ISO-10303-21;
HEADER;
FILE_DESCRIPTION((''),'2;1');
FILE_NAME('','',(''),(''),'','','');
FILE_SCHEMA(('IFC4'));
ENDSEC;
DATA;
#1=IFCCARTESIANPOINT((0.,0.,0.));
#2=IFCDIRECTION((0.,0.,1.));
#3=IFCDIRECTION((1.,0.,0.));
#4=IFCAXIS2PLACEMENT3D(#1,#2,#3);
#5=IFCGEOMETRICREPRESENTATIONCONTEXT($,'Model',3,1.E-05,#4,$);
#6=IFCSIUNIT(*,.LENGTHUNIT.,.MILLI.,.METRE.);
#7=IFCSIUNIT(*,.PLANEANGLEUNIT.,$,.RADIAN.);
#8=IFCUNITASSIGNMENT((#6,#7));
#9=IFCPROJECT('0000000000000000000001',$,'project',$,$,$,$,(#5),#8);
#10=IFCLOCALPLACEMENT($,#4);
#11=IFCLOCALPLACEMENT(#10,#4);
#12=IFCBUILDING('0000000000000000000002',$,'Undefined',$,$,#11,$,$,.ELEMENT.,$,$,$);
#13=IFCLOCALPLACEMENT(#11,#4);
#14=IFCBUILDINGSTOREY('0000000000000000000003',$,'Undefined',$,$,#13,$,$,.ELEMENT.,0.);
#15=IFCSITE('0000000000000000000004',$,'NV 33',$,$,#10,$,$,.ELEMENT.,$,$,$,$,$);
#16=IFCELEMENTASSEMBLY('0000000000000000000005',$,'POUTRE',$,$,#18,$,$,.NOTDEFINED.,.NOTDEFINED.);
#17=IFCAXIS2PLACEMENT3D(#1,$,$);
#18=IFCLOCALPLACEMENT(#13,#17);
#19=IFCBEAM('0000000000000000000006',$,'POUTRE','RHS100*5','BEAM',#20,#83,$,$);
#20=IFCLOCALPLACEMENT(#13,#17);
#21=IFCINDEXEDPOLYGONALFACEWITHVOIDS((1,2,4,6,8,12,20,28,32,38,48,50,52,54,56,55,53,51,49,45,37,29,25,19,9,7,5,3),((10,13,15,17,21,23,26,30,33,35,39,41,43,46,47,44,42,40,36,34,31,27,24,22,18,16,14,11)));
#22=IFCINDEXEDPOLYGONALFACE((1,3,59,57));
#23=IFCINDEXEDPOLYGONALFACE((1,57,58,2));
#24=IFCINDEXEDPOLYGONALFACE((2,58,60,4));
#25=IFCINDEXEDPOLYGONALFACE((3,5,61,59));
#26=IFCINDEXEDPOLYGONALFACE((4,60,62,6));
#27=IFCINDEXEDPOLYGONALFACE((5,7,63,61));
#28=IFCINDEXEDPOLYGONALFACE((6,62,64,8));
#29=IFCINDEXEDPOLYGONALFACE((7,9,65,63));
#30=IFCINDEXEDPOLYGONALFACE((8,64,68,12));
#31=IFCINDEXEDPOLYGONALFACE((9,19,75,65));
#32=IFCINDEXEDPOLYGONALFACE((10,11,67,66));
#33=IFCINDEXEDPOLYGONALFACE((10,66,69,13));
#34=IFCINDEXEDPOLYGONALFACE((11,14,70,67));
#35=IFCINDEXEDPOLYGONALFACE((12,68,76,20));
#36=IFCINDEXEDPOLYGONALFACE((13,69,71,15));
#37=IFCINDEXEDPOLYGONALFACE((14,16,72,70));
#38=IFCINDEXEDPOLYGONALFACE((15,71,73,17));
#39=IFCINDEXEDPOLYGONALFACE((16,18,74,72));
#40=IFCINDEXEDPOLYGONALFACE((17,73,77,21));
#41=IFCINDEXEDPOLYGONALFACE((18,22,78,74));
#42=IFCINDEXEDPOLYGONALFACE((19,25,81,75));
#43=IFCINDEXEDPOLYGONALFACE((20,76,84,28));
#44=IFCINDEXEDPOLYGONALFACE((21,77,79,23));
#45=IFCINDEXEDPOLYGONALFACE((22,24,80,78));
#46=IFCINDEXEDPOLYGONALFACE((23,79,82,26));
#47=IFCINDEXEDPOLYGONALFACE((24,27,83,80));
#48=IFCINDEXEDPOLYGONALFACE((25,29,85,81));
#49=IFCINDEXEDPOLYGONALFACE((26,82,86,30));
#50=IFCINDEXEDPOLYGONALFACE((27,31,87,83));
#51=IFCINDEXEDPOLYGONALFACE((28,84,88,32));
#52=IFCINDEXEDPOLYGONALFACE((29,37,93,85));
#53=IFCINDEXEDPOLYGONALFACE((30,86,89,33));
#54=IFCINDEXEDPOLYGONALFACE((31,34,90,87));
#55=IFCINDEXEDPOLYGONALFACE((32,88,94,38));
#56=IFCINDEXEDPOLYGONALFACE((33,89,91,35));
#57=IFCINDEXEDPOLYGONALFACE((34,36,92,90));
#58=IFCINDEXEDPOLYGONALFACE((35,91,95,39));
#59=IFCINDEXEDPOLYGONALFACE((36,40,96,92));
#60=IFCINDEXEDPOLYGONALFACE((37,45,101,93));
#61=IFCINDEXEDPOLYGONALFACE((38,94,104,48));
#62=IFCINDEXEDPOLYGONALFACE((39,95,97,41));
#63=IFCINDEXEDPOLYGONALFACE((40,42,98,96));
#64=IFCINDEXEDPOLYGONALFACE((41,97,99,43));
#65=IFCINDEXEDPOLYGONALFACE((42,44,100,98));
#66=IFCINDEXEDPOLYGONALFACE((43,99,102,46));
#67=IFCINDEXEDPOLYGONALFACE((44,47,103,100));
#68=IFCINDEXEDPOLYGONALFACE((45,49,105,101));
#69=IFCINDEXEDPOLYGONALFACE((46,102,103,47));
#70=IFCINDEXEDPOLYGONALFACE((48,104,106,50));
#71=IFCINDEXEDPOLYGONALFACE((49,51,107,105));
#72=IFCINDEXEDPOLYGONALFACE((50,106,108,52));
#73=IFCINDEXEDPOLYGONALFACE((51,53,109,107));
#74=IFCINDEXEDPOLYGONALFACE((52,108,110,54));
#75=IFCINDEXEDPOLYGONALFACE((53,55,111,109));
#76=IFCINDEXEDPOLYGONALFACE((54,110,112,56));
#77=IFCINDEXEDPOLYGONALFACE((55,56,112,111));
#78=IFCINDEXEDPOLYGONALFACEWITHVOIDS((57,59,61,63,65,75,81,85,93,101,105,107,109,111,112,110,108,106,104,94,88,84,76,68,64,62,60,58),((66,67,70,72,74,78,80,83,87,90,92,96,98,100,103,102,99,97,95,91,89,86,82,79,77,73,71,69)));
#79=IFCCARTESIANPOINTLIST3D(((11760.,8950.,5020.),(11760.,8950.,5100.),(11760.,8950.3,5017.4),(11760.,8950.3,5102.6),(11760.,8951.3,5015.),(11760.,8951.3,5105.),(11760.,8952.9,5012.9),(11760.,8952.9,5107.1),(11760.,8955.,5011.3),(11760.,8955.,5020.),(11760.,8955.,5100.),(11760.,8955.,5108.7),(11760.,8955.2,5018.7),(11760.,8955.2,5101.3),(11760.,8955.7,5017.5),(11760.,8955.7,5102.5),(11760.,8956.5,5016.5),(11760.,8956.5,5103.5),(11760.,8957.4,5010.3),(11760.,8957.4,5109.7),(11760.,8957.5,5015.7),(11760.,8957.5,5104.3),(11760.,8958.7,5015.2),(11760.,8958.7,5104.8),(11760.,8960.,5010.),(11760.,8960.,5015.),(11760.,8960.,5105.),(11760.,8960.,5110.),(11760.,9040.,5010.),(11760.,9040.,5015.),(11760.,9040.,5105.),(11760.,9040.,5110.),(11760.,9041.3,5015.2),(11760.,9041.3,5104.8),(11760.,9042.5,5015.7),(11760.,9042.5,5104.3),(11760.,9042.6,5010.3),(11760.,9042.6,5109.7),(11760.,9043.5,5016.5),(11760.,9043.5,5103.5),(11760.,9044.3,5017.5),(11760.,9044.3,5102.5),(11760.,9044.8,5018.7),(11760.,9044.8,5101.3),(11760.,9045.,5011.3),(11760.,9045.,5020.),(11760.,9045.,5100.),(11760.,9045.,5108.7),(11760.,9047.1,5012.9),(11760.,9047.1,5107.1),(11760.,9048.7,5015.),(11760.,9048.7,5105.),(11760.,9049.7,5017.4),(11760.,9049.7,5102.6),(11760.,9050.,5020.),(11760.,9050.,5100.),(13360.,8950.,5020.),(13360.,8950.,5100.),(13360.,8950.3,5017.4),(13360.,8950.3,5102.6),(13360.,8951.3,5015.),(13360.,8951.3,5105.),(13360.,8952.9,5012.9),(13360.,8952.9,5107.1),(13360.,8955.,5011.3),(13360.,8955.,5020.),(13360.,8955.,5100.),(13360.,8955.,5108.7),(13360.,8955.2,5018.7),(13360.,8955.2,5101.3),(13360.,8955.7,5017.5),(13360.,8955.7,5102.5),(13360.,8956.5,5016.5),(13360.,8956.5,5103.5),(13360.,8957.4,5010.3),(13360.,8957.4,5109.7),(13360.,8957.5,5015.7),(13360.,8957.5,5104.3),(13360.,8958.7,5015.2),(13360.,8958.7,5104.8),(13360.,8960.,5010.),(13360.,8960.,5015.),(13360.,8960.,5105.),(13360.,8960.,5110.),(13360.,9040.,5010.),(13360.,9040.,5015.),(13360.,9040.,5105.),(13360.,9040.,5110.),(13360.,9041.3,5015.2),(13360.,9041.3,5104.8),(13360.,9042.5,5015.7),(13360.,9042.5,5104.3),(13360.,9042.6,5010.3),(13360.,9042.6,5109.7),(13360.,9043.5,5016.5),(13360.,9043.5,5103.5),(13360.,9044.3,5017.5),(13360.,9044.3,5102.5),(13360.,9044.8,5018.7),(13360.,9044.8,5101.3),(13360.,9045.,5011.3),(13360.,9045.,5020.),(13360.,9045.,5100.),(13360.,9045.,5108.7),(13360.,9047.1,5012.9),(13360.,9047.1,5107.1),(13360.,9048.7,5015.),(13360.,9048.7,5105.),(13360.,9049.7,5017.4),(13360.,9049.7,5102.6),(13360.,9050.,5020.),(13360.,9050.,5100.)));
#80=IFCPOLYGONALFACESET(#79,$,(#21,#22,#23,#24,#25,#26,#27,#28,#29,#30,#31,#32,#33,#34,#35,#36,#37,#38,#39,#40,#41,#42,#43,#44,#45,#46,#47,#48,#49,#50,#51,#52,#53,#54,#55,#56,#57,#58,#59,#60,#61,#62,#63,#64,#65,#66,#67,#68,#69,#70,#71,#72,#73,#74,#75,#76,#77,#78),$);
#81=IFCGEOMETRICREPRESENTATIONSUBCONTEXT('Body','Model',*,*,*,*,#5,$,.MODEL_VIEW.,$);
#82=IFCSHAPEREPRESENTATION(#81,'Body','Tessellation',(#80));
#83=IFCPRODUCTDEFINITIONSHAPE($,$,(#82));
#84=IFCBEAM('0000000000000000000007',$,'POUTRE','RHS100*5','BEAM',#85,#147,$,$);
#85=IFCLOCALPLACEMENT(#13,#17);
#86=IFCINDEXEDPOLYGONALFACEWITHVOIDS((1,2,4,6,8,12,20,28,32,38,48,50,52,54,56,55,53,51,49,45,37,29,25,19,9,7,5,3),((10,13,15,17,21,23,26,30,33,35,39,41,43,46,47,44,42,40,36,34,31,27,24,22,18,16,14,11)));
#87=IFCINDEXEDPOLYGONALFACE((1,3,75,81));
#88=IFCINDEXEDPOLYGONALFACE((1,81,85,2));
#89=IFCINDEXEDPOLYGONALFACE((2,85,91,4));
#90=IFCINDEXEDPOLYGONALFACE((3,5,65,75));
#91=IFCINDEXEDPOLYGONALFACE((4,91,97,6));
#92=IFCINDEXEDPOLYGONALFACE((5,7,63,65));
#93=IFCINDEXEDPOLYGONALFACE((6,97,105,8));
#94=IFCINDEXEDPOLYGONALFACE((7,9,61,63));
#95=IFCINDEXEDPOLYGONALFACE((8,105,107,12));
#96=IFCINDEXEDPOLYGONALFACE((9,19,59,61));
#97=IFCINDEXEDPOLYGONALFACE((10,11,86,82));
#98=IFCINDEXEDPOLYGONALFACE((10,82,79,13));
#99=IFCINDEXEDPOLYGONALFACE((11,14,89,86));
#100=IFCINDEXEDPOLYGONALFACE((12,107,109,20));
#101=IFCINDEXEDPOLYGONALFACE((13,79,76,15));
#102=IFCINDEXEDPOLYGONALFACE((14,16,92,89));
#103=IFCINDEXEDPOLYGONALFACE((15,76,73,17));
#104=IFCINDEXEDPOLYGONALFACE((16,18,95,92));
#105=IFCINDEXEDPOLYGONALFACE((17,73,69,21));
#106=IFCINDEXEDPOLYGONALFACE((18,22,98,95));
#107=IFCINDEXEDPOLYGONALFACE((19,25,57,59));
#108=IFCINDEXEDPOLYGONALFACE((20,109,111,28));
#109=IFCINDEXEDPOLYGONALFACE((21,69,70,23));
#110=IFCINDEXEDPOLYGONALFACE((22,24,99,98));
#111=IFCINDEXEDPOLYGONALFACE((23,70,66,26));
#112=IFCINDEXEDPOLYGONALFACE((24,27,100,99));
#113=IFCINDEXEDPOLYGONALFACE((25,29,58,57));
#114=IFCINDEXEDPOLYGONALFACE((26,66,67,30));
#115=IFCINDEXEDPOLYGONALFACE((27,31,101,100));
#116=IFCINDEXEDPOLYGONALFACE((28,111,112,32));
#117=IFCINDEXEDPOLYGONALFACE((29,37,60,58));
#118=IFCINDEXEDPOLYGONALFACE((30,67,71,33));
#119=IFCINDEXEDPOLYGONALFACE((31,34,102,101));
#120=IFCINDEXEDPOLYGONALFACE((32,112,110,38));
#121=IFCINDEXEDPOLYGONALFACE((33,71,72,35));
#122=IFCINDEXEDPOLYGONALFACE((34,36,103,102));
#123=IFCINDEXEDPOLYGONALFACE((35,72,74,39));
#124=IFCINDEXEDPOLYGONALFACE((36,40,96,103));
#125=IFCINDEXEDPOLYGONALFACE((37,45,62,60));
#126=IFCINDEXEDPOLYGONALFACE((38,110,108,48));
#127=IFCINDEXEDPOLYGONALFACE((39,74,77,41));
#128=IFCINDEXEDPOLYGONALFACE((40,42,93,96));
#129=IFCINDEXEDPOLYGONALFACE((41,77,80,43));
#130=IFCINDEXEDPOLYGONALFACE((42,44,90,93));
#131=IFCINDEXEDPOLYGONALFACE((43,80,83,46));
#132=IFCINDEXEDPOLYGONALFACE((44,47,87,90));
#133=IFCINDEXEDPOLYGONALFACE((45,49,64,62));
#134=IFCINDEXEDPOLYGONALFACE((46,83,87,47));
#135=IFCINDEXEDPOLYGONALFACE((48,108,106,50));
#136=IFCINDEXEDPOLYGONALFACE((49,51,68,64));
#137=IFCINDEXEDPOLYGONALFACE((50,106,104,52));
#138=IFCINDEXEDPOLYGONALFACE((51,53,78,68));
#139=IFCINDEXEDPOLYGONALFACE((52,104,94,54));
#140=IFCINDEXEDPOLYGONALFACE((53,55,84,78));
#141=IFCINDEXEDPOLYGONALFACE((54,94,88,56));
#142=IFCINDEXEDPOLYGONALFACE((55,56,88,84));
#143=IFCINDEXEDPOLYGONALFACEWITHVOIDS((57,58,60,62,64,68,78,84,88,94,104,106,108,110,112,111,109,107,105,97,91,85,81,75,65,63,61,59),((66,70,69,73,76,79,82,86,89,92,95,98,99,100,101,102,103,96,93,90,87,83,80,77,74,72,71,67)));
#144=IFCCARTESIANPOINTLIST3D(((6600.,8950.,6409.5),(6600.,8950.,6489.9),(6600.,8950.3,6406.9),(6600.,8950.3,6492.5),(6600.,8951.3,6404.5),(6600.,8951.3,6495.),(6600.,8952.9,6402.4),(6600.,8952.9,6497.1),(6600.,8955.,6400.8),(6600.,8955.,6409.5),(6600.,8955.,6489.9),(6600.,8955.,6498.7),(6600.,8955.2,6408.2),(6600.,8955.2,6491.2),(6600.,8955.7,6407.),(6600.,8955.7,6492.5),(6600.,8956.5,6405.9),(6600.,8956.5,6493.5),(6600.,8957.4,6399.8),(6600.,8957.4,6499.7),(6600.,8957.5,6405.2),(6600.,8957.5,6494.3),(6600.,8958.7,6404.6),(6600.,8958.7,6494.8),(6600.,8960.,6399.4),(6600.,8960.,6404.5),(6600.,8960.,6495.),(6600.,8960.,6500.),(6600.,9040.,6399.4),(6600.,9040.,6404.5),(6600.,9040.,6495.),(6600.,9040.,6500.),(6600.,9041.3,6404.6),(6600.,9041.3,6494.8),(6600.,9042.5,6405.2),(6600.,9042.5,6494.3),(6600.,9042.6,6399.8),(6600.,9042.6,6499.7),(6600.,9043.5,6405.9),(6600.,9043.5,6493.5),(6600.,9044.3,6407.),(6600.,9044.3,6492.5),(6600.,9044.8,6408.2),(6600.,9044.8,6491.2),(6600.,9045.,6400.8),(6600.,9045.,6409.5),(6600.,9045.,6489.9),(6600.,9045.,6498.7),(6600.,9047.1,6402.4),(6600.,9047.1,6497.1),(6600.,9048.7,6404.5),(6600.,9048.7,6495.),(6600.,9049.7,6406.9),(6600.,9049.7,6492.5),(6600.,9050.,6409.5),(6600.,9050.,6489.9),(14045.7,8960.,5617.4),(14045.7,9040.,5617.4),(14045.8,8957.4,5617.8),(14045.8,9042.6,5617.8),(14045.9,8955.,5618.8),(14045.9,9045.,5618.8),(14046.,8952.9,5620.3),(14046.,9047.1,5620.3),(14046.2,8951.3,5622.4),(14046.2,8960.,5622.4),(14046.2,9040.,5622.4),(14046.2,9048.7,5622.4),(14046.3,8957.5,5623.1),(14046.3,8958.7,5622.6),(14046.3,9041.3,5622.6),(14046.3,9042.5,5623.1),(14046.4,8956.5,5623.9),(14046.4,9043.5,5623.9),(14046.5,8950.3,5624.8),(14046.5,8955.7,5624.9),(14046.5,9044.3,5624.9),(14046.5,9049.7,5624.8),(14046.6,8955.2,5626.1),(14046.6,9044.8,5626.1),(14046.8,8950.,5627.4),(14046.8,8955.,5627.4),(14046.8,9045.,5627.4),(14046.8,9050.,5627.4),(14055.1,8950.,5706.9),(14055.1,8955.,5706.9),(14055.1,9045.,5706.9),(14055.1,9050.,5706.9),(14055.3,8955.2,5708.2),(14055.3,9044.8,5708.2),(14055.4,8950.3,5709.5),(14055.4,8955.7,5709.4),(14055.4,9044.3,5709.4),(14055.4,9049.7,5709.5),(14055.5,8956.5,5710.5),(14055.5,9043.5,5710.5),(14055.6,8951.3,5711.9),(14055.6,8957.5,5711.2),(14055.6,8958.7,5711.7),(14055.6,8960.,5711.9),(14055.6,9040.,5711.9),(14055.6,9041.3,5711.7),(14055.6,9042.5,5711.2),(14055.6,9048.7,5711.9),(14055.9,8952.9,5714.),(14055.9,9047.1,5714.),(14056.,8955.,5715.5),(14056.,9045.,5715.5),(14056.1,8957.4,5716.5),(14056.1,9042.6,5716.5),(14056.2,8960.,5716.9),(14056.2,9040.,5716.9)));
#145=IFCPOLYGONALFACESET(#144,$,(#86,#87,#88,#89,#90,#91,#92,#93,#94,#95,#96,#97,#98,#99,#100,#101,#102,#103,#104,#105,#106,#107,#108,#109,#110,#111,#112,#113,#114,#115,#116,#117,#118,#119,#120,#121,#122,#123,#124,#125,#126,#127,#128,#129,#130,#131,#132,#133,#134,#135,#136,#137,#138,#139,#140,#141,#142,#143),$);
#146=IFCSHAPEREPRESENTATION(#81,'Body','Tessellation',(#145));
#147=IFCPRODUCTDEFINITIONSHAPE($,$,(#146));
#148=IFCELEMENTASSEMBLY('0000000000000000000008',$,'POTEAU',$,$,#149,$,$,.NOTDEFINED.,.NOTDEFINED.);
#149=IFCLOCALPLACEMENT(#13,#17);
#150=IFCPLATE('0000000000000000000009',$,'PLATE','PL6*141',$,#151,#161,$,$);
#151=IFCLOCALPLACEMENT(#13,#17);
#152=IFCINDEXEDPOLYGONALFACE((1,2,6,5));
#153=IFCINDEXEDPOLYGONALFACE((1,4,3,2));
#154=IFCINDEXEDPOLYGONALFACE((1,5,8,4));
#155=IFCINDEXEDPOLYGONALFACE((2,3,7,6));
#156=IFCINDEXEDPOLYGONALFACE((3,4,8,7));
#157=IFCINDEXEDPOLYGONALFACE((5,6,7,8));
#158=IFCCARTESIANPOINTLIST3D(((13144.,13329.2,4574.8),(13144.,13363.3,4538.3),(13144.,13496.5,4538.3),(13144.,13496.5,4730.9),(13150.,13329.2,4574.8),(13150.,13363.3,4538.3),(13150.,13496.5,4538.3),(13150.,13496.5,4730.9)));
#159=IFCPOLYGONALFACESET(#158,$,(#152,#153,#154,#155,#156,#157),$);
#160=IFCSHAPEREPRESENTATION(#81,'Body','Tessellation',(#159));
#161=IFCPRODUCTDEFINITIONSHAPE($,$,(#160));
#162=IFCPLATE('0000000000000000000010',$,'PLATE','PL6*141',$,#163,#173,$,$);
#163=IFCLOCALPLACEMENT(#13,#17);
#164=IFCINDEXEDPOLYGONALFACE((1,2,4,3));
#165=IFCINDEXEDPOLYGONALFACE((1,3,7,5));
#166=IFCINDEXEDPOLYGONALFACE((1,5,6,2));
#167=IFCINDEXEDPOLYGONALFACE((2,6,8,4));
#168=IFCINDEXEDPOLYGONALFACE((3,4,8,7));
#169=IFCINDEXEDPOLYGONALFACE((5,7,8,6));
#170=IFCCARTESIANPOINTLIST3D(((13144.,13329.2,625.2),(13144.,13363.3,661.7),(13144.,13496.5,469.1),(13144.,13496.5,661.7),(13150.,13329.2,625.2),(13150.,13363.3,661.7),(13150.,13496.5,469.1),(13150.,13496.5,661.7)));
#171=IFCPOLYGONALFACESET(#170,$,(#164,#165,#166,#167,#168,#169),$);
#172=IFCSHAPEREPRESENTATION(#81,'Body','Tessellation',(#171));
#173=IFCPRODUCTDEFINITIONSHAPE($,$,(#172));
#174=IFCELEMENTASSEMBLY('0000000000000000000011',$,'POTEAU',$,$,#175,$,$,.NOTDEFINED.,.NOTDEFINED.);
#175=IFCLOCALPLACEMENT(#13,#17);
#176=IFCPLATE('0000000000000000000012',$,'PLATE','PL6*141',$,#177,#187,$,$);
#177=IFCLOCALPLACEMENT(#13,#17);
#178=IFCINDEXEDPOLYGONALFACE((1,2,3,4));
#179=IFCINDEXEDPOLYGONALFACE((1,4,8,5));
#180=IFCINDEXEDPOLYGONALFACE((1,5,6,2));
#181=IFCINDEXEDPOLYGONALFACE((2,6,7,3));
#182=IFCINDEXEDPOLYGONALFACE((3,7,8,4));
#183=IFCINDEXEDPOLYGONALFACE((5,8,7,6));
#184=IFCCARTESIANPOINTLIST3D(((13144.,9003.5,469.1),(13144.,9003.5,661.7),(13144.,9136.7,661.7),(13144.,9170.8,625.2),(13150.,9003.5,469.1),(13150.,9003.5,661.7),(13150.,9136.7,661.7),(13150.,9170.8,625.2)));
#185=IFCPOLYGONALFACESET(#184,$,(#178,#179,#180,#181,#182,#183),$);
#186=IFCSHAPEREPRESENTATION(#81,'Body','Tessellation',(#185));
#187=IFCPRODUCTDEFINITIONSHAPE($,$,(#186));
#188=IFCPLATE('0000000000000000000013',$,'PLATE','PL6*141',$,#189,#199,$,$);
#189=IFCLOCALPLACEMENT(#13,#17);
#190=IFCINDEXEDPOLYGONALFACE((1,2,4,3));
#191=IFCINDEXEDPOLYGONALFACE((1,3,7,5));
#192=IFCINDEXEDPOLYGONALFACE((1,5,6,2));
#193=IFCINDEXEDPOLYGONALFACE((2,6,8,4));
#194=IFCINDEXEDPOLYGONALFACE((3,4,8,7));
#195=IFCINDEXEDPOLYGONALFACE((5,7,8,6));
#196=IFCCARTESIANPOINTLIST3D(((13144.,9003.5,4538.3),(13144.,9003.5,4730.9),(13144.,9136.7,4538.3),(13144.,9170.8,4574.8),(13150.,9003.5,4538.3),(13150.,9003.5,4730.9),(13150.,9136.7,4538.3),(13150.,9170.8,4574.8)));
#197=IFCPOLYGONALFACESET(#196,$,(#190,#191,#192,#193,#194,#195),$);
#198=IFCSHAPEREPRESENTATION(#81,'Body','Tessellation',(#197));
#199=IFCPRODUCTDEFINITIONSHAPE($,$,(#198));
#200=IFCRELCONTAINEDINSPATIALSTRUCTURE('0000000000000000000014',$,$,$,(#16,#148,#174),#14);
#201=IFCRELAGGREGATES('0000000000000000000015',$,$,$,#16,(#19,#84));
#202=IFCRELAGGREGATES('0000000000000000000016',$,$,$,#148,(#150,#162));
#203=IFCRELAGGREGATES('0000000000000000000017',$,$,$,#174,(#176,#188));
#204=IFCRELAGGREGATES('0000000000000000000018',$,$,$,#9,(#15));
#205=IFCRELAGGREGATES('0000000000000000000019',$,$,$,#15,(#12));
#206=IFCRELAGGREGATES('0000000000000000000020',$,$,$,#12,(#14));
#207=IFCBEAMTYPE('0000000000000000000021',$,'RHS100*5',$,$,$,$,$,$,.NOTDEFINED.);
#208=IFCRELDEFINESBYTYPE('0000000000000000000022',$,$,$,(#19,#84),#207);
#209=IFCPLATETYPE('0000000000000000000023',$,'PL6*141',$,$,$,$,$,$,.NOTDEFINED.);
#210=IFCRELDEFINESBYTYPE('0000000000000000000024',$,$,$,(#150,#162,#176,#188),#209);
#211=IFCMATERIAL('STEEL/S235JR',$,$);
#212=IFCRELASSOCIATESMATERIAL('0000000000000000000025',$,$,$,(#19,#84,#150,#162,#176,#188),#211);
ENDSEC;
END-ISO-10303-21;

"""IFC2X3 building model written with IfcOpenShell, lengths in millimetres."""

from ifc_helpers import new_model, si_unit, frame, origin_with_axes, origin_2d_with_axis, place, context, subcontext, project, spatial, polyline, hollow_rectangle, outline, extrude, clip, halfspace, material, type_object, element, aggregate, save


model = new_model("IFC2X3")

# Units and contexts
model_context = context("Model", 3, precision=1e-05, world=origin_with_axes())
body_context = subcontext(model_context, "Body", "Model", "MODEL_VIEW")
ifc_project = project(units=[si_unit("LENGTHUNIT", "METRE", prefix="MILLI"), si_unit("PLANEANGLEUNIT", "RADIAN")], contexts=[model_context])

# Site, building, storey
site_placement = place(None, origin_with_axes())
site = spatial("IfcSite", under=ifc_project, at=site_placement, Name="NV 33", CompositionType="ELEMENT")
building_placement = place(site_placement, origin_with_axes())
building = spatial("IfcBuilding", under=site, at=building_placement, Name="Undefined", CompositionType="ELEMENT")
storey_placement = place(building_placement, origin_with_axes())
storey = spatial("IfcBuildingStorey", under=building, at=storey_placement, Name="Undefined", CompositionType="ELEMENT", Elevation=0.0)

# Shared definitions
ifc_material_1 = material(Name="STEEL/S235JR")

# Element assembly, beams
beam_type_1 = type_object("IfcBeamType", Name="RHS100*5", PredefinedType="NOTDEFINED")
assembly_1_placement = place(storey_placement, origin_with_axes())
assembly_1 = element("IfcElementAssembly", 1, at=assembly_1_placement, inside=storey, Name="POUTRE", AssemblyPlace="NOTDEFINED", PredefinedType="NOTDEFINED")
beam_1_placement = place(assembly_1_placement, frame((13360.0, 9000.0, 5060.0), z_axis=(0.0, -1.0, 0.0), x_axis=(-1.0, 0.0, 0.0)))
beam_1 = element("IfcBeam", 2, at=beam_1_placement, type_object=beam_type_1, material=ifc_material_1, Name="POUTRE", Description="RHS100*5", ObjectType="BEAM", context=body_context, shape_type="SweptSolid", body=[
    extrude(hollow_rectangle(XDim=100.0, YDim=100.0, WallThickness=5.0, InnerFilletRadius=5.0, OuterFilletRadius=10.0, at=origin_2d_with_axis()), frame((1600.0, 0.0, 0.0), z_axis=(-1.0, 0.0, 0.0), x_axis=(0.0, -1.0, 0.0)), (0.0, 0.0, 1.0), 1600.0),
])
beam_2_placement = place(assembly_1_placement, frame((14050.9, 9000.0, 5667.2), z_axis=(-0.104455, 0.0, -0.99453), x_axis=(-0.99453, 0.0, 0.104455)))
beam_2 = element("IfcBeam", 3, at=beam_2_placement, type_object=beam_type_1, material=ifc_material_1, Name="POUTRE", Description="RHS100*5", ObjectType="BEAM", context=body_context, shape_type="Clipping", body=[
    clip(extrude(hollow_rectangle(XDim=100.0, YDim=100.0, WallThickness=5.0, InnerFilletRadius=5.0, OuterFilletRadius=10.0, at=origin_2d_with_axis()), frame((7527.2, 0.0, 0.0), z_axis=(-1.0, 0.0, 0.0), x_axis=(0.0, -1.0, 0.0)), (0.0, 0.0, 1.0), 7527.2), halfspace(frame((7497.2, 50.0, -50.0), z_axis=(0.99453, 0.0, 0.104455), x_axis=(0.0, -1.0, 0.0)), False)),
])
aggregate(assembly_1, [beam_1, beam_2])

# Element assemblies, plates
assembly_2_placement = place(storey_placement, origin_with_axes())
assembly_2 = element("IfcElementAssembly", 4, at=assembly_2_placement, inside=storey, Name="POTEAU", AssemblyPlace="NOTDEFINED", PredefinedType="NOTDEFINED")
plate_type_1 = type_object("IfcPlateType", Name="PL6*141", PredefinedType="NOTDEFINED")
plate_1_placement = place(assembly_2_placement, frame((13147.0, 13496.5, 4538.3), z_axis=(1.0, 0.0, 0.0), x_axis=(0.0, 0.0, 1.0)))
plate_1 = element("IfcPlate", 5, at=plate_1_placement, type_object=plate_type_1, material=ifc_material_1, Name="PLATE", Description="PL6*141", context=body_context, shape_type="SweptSolid", body=[
    extrude(outline(polyline([(0.0, 0.0), (192.6, 0.0), (36.6, 167.2), (0.0, 133.1), (0.0, 0.0)])), frame((0.0, 0.0, -3.0), z_axis=(0.0, 0.0, 1.0), x_axis=(1.0, 0.0, 0.0)), (0.0, 0.0, 1.0), 6.0),
])
plate_2_placement = place(assembly_2_placement, frame((13147.0, 13496.5, 469.1), z_axis=(1.0, 0.0, 0.0), x_axis=(0.0, 0.0, 1.0)))
plate_2 = element("IfcPlate", 6, at=plate_2_placement, type_object=plate_type_1, material=ifc_material_1, Name="PLATE", Description="PL6*141", context=body_context, shape_type="SweptSolid", body=[
    extrude(outline(polyline([(0.0, 0.0), (192.6, 0.0), (192.6, 133.1), (156.1, 167.2), (0.0, 0.0)])), frame((0.0, 0.0, -3.0), z_axis=(0.0, 0.0, 1.0), x_axis=(1.0, 0.0, 0.0)), (0.0, 0.0, 1.0), 6.0),
])
assembly_3_placement = place(storey_placement, origin_with_axes())
assembly_3 = element("IfcElementAssembly", 7, at=assembly_3_placement, inside=storey, Name="POTEAU", AssemblyPlace="NOTDEFINED", PredefinedType="NOTDEFINED")
plate_3_placement = place(assembly_3_placement, frame((13147.0, 9003.5, 661.7), z_axis=(1.0, 0.0, 0.0), x_axis=(0.0, 0.0, -1.0)))
plate_3 = element("IfcPlate", 8, at=plate_3_placement, type_object=plate_type_1, material=ifc_material_1, Name="PLATE", Description="PL6*141", context=body_context, shape_type="SweptSolid", body=[
    extrude(outline(polyline([(0.0, 0.0), (192.6, 0.0), (36.6, 167.2), (0.0, 133.1), (0.0, 0.0)])), frame((0.0, 0.0, -3.0), z_axis=(0.0, 0.0, 1.0), x_axis=(1.0, 0.0, 0.0)), (0.0, 0.0, 1.0), 6.0),
])
plate_4_placement = place(assembly_3_placement, frame((13147.0, 9003.5, 4730.9), z_axis=(1.0, 0.0, 0.0), x_axis=(0.0, 0.0, -1.0)))
plate_4 = element("IfcPlate", 9, at=plate_4_placement, type_object=plate_type_1, material=ifc_material_1, Name="PLATE", Description="PL6*141", context=body_context, shape_type="SweptSolid", body=[
    extrude(outline(polyline([(0.0, 0.0), (192.6, 0.0), (192.6, 133.1), (156.1, 167.2), (0.0, 0.0)])), frame((0.0, 0.0, -3.0), z_axis=(0.0, 0.0, 1.0), x_axis=(1.0, 0.0, 0.0)), (0.0, 0.0, 1.0), 6.0),
])

aggregate(assembly_2, [plate_1, plate_2])
aggregate(assembly_3, [plate_3, plate_4])

save(model, "model.ifc")
